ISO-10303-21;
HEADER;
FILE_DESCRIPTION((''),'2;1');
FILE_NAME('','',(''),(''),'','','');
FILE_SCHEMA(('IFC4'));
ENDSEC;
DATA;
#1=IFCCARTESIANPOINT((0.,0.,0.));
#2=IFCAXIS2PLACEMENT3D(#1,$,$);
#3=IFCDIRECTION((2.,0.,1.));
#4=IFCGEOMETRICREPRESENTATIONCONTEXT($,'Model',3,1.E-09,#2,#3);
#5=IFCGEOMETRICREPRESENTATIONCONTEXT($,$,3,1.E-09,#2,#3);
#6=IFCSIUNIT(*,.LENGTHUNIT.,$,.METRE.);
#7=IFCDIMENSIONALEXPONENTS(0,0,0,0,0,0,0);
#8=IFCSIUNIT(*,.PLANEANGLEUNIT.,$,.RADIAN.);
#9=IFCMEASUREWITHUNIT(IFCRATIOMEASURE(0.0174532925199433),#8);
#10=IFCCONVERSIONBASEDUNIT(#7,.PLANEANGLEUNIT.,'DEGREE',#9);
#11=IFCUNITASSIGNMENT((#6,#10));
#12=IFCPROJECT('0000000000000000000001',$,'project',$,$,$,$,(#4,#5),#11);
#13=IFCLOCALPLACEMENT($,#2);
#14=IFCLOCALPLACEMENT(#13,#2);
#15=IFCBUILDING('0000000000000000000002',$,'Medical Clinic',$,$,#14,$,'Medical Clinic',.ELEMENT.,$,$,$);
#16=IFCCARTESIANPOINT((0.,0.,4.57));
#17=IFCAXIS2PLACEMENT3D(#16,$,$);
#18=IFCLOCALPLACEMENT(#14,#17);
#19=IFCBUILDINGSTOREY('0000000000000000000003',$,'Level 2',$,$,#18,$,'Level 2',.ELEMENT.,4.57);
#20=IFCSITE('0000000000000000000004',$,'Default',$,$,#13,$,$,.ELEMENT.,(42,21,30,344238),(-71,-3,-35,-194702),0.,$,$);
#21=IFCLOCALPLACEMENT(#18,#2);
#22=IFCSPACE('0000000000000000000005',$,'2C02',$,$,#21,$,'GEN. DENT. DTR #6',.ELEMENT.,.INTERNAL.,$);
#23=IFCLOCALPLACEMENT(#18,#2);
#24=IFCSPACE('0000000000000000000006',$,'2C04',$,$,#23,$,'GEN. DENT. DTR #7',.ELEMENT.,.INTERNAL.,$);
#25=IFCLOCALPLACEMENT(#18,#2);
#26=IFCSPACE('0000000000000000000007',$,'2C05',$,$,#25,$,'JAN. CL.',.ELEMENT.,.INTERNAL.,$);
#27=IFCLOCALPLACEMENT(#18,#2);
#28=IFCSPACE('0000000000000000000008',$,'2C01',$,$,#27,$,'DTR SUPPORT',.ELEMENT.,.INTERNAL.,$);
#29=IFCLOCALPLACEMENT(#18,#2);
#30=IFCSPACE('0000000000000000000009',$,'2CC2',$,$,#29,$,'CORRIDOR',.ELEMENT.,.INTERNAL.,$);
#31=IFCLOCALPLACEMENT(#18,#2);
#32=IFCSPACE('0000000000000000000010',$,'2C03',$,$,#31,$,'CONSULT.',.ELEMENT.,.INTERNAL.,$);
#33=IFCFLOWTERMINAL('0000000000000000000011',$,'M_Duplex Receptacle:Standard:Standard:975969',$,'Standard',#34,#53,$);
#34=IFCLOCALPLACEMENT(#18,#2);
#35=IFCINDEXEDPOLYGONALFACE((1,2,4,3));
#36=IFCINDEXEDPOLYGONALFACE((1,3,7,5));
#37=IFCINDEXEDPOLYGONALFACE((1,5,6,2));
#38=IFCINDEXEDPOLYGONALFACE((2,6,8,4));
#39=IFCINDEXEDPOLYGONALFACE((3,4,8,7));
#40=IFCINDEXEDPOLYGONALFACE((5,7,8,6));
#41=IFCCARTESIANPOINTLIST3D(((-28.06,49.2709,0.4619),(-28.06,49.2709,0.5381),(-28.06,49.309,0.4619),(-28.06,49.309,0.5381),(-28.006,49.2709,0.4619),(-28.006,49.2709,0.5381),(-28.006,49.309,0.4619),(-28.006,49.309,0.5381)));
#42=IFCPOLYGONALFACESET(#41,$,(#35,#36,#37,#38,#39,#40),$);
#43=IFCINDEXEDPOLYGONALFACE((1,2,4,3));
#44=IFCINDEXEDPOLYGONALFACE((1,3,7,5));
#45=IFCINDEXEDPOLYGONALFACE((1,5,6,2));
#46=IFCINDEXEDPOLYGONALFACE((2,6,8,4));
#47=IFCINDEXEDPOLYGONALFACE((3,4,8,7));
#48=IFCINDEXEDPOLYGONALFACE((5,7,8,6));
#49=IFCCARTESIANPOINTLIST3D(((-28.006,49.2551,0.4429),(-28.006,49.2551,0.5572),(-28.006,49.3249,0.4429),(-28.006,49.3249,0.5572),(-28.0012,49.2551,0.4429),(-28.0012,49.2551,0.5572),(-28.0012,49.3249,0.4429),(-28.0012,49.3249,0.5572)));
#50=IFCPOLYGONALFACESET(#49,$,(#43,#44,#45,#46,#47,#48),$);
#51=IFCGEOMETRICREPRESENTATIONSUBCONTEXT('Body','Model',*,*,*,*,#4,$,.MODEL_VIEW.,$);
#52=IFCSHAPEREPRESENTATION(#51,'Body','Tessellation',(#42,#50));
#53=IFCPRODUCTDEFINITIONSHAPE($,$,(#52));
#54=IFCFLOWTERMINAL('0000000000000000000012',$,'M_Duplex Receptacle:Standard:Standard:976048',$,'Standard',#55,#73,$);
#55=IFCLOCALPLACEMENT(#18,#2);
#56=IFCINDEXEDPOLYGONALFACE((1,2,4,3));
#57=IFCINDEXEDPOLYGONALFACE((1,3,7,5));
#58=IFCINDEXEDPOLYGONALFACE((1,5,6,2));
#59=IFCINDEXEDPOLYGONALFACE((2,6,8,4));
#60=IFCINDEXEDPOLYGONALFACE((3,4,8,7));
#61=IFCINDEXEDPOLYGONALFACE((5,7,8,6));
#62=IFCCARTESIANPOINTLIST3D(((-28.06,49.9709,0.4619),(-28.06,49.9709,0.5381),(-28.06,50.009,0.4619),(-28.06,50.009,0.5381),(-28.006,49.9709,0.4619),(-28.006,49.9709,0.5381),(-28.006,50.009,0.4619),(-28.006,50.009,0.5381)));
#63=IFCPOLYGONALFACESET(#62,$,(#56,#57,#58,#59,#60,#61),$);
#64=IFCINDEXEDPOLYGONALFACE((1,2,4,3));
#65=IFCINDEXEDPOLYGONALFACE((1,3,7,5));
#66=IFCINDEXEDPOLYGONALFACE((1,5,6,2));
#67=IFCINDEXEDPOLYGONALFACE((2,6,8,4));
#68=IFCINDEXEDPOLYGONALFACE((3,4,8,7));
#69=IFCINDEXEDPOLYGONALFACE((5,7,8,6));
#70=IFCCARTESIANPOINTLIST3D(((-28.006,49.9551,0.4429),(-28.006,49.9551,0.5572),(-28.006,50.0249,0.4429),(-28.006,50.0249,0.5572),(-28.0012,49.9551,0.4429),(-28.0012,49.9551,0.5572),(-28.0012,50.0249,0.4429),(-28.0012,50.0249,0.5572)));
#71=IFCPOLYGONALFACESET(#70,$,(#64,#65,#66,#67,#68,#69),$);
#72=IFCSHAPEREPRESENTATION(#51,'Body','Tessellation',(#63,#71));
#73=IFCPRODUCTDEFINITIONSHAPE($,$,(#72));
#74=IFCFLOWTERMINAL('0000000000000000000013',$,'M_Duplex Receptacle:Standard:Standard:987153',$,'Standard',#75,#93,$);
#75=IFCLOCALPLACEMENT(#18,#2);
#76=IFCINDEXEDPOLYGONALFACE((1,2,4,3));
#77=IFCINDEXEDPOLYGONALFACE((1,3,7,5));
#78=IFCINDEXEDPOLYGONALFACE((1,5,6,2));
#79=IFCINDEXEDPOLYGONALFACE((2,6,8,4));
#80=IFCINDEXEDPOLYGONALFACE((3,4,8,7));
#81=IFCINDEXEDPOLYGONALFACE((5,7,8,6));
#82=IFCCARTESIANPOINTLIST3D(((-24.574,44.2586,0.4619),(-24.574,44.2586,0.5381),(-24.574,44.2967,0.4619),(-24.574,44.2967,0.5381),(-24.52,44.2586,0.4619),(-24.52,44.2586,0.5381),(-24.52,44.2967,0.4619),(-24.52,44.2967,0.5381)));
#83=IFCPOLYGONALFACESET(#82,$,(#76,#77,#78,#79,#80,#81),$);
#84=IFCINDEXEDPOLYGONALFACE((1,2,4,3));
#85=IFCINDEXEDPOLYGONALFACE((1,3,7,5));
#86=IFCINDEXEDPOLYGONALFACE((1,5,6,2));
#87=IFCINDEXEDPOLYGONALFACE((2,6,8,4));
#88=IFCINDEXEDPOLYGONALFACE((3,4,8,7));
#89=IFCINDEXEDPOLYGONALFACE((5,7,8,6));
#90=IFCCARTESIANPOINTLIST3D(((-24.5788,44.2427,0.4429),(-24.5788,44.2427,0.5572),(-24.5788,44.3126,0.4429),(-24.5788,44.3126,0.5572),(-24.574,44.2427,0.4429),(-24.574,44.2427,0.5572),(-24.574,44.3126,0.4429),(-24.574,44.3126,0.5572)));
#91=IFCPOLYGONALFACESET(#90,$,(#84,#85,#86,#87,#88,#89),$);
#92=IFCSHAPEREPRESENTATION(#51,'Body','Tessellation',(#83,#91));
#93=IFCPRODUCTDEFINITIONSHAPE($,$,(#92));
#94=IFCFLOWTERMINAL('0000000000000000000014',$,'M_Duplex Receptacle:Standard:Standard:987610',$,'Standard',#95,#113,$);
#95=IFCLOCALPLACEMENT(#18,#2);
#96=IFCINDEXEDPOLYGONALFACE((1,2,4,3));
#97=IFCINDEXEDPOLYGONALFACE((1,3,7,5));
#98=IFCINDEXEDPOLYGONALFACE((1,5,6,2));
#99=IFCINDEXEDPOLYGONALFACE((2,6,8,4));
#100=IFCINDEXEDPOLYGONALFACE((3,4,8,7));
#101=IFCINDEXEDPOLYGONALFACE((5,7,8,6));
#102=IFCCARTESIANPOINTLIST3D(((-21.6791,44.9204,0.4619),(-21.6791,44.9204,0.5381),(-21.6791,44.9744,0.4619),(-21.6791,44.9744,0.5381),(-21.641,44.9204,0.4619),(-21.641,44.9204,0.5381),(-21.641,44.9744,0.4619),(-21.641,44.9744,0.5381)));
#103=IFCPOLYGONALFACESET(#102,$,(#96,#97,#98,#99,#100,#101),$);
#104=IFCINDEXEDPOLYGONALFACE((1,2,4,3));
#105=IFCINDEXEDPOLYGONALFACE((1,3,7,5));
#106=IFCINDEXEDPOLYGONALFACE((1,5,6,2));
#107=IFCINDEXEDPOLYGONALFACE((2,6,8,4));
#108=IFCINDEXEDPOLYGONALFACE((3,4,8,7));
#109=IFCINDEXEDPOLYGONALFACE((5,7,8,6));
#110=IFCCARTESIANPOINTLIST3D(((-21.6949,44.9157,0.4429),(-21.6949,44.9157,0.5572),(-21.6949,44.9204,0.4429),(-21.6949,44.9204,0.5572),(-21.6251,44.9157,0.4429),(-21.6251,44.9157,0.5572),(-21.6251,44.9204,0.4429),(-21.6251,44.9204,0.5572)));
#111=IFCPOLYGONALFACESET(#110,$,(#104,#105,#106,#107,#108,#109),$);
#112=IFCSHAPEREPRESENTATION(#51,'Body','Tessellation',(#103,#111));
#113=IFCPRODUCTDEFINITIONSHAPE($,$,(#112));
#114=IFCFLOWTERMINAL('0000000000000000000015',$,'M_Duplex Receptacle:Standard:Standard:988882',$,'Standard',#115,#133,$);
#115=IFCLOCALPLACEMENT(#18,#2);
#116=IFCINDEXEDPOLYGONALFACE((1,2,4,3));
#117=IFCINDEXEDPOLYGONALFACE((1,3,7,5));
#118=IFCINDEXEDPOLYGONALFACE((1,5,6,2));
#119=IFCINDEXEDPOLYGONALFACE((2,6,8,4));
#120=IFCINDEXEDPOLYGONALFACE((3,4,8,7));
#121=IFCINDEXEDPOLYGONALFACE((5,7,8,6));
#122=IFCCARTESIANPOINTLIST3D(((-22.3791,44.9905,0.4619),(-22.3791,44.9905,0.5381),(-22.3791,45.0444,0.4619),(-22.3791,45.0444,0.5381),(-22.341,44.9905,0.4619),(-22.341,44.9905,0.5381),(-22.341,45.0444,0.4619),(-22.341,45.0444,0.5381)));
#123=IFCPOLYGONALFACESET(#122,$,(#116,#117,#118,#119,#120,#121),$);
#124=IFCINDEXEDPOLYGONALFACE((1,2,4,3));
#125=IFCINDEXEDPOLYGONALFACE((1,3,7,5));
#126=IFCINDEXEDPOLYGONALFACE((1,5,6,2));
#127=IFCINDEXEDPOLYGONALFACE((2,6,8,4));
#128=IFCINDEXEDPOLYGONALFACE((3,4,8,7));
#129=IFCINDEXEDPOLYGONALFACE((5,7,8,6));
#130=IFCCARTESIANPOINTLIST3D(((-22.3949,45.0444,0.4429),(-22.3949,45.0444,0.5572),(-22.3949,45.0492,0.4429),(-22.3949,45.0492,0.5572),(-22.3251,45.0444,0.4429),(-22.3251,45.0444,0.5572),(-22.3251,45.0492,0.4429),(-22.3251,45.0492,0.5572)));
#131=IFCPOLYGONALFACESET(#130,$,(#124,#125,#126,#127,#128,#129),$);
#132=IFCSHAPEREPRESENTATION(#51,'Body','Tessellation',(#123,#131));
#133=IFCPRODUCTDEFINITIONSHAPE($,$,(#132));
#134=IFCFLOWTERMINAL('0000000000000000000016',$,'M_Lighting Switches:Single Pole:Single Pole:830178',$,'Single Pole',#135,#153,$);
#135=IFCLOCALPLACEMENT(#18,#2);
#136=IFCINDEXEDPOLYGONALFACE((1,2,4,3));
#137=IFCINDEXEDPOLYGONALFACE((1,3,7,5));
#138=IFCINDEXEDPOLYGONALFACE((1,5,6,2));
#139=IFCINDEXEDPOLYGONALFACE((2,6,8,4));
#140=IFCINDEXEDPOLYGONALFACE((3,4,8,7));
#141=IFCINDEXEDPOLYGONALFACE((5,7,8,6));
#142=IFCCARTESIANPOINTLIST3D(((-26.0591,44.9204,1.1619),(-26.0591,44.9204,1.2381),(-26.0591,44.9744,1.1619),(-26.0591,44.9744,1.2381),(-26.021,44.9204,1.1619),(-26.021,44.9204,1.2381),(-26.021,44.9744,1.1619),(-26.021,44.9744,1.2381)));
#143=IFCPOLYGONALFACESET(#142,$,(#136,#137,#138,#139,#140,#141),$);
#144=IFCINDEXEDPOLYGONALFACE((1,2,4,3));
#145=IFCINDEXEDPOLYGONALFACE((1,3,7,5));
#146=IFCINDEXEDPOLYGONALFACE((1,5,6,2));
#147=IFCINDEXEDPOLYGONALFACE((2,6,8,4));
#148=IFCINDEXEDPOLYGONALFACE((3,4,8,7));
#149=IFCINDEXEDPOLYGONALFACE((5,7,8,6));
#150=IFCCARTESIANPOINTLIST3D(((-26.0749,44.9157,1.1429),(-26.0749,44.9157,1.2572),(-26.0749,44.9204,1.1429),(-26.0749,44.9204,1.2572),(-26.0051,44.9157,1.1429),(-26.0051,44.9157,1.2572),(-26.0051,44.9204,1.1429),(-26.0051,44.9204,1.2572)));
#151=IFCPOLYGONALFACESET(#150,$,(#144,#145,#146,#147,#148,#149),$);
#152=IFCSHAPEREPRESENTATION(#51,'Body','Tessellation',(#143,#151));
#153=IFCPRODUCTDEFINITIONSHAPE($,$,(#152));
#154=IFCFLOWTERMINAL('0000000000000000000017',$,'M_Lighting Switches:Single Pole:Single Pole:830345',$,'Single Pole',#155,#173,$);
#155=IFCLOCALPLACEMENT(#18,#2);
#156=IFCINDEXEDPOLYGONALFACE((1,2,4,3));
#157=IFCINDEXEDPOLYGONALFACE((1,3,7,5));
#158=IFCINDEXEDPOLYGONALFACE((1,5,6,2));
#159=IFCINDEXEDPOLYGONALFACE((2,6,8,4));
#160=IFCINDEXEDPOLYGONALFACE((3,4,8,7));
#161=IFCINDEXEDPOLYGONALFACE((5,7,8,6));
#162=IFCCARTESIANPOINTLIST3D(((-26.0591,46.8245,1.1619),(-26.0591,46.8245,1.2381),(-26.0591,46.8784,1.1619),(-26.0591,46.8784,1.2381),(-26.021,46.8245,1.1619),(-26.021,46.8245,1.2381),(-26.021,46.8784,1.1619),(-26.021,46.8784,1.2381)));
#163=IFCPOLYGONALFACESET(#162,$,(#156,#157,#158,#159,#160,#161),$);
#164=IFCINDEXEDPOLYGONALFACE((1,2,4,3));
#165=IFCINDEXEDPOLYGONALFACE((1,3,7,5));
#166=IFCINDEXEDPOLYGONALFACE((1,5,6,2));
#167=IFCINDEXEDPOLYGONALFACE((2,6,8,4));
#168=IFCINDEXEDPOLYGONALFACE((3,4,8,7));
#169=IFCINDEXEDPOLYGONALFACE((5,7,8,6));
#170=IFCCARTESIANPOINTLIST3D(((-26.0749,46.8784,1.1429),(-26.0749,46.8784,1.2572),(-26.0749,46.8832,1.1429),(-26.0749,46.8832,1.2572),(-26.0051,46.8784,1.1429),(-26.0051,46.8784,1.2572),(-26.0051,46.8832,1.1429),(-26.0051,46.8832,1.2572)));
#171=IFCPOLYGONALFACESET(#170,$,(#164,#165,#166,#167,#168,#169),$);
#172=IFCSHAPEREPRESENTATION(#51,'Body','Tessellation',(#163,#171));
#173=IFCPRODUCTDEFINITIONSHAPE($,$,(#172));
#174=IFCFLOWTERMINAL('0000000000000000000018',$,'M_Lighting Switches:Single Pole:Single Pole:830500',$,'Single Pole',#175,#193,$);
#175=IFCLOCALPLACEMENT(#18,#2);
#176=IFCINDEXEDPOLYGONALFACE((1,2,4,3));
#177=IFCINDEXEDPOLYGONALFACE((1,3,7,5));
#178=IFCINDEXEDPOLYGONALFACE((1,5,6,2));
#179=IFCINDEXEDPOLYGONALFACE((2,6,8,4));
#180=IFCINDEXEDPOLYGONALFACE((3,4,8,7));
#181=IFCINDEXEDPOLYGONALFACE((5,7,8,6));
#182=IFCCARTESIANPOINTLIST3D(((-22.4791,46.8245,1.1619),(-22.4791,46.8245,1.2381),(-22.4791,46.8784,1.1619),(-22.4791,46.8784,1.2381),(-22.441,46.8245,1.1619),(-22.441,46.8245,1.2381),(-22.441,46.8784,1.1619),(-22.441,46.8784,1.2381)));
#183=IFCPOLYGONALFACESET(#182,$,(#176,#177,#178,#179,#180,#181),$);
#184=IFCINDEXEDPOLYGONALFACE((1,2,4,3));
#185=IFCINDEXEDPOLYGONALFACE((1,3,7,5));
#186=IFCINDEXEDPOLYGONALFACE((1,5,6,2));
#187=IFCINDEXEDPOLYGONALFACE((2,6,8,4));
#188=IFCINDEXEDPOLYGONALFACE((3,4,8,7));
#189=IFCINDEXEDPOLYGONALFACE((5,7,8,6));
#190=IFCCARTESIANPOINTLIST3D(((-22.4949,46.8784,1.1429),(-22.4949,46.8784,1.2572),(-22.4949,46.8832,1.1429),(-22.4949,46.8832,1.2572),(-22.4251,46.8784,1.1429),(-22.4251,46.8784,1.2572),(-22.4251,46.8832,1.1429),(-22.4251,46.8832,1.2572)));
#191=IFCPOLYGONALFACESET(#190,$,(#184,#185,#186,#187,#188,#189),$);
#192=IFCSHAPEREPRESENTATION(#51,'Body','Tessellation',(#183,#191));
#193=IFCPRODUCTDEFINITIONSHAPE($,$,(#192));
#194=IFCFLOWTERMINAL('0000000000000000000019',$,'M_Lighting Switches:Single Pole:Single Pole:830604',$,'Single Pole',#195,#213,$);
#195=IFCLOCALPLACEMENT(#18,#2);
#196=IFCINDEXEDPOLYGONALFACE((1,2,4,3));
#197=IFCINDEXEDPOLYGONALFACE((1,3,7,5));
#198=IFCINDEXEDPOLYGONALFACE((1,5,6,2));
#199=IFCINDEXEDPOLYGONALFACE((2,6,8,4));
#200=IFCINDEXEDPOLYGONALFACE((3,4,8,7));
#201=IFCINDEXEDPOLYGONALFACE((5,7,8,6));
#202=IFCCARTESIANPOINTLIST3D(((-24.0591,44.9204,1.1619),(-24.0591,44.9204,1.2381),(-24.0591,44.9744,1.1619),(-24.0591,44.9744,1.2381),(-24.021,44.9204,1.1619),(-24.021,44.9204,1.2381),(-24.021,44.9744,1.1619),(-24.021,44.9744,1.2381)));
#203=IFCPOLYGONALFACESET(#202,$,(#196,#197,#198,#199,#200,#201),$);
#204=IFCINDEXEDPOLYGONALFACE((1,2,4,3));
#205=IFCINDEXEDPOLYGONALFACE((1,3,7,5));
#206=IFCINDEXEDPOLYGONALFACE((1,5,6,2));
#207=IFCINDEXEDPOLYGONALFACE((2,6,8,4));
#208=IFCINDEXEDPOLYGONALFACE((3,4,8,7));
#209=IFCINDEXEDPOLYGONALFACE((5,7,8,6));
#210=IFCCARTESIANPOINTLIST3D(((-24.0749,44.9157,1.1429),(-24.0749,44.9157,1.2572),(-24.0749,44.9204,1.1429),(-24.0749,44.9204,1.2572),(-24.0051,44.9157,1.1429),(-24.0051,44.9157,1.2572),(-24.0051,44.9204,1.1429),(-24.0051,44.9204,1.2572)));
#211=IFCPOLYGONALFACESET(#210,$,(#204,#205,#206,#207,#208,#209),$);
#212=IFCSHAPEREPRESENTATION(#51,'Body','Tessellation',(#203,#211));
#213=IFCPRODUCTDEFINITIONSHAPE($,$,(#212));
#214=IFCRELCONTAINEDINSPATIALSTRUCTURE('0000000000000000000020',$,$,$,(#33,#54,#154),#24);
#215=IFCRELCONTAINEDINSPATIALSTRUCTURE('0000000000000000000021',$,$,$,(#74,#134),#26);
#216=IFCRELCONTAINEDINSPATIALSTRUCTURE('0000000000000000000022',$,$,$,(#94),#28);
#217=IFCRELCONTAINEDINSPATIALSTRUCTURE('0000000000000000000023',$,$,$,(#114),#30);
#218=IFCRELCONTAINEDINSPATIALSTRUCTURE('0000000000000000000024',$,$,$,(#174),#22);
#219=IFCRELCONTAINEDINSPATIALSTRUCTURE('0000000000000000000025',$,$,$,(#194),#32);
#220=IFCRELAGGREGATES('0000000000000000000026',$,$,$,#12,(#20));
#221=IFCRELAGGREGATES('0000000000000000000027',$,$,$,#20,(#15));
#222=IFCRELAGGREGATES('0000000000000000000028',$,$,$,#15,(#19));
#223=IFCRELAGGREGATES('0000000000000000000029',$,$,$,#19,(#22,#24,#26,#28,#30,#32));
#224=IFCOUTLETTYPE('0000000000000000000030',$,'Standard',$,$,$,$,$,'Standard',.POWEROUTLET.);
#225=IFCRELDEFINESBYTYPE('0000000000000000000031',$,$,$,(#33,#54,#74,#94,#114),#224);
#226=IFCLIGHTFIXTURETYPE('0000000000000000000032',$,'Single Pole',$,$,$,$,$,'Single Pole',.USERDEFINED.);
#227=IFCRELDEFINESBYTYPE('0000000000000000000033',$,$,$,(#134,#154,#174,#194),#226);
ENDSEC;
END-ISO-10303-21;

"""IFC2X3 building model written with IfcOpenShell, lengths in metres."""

from ifc_helpers import new_model, entity, si_unit, converted_unit, direction, frame, frame_2d, origin, origin_2d_with_axis, place, context, subcontext, project, spatial, rectangle, extrude, source, transform, mapped, type_object, type_shapes, element, save


model = new_model("IFC2X3")

# Units and contexts
model_context = context("Model", 3, precision=1e-09, world=origin(), true_north=direction((2.0, 0.0, 1.0)))
context_of_model = context(None, 3, precision=1e-09, world=origin(), true_north=direction((2.0, 0.0, 1.0)))
body_context = subcontext(model_context, "Body", "Model", "MODEL_VIEW")
ifc_project = project(units=[si_unit("LENGTHUNIT", "METRE"), converted_unit("PLANEANGLEUNIT", "DEGREE", entity("IfcRatioMeasure", 0.0174532925199433), si_unit("PLANEANGLEUNIT", "RADIAN"), dimensions=[0, 0, 0, 0, 0, 0, 0])], contexts=[model_context, context_of_model])

# Site, building, storey, space
site_placement = place(None, origin())
site = spatial("IfcSite", under=ifc_project, at=site_placement, Name="Default", CompositionType="ELEMENT", RefLatitude=(42, 21, 30, 344238), RefLongitude=(-71, -3, -35, -194702), RefElevation=0.0)
building_placement = place(site_placement, origin())
building = spatial("IfcBuilding", under=site, at=building_placement, Name="Medical Clinic", LongName="Medical Clinic", CompositionType="ELEMENT")
storey_placement = place(building_placement, frame((0.0, 0.0, 4.57)))
storey = spatial("IfcBuildingStorey", under=building, at=storey_placement, Name="Level 2", LongName="Level 2", CompositionType="ELEMENT", Elevation=4.57)
space_1_placement = place(storey_placement, origin())
space_1 = spatial("IfcSpace", under=storey, at=space_1_placement, Name="2C02", LongName="GEN. DENT. DTR #6", CompositionType="ELEMENT", InteriorOrExteriorSpace="INTERNAL")

# Shared definitions
outlet_type = type_object("IfcOutletType", Name="Standard", ElementType="Standard", PredefinedType="POWEROUTLET")
shared_shape_1 = source(origin(), body_context, "Body", "SweptSolid", [
    extrude(rectangle(XDim=0.0381, YDim=0.0762, at=origin_2d_with_axis()), frame((0.0, 0.0, -0.054), z_axis=(0.0, 0.0, 1.0), x_axis=(-1.0, 0.0, 0.0)), (0.0, 0.0, 1.0), 0.054),
    extrude(rectangle(XDim=0.0698, YDim=0.1143, at=frame_2d((0.0, 0.0), x_axis=(1.0, 0.0))), frame((0.0, 0.0, 0.0), z_axis=(0.0, 0.0, 1.0), x_axis=(-1.0, 0.0, 0.0)), (0.0, 0.0, 1.0), 0.0048),
])
type_shapes(outlet_type, [shared_shape_1])

# Shared definitions
space_2_placement = place(storey_placement, origin())
space_2 = spatial("IfcSpace", under=storey, at=space_2_placement, Name="2C04", LongName="GEN. DENT. DTR #7", CompositionType="ELEMENT", InteriorOrExteriorSpace="INTERNAL")

# Flow terminals
for number, where, z_axis, x_axis, name in (
    (1, (-28.006, 49.29, 0.5), (1.0, 0.0, 0.0), (0.0, 1.0, 0.0), "M_Duplex Receptacle:Standard:Standard:975969"),
    (2, (-28.006, 49.99, 0.5), (1.0, 0.0, 0.0), (0.0, 1.0, 0.0), "M_Duplex Receptacle:Standard:Standard:976048"),
):
    element("IfcFlowTerminal", number, at=place(space_2_placement, frame(where, z_axis=z_axis, x_axis=x_axis)), inside=space_2, type_object=outlet_type, Name=name, ObjectType="Standard", context=body_context, shape_type="MappedRepresentation", body=[
        mapped(shared_shape_1, transform((0.0, 0.0, 0.0), scale=1.0)),
    ])

# Shared definitions
space_3_placement = place(storey_placement, origin())
space_3 = spatial("IfcSpace", under=storey, at=space_3_placement, Name="2C05", LongName="JAN. CL.", CompositionType="ELEMENT", InteriorOrExteriorSpace="INTERNAL")

# Flow terminal
flow_terminal_1_placement = place(space_3_placement, frame((-24.574, 44.2776, 0.5), z_axis=(-1.0, 0.0, 0.0), x_axis=(0.0, -1.0, 0.0)))
element("IfcFlowTerminal", 3, at=flow_terminal_1_placement, inside=space_3, type_object=outlet_type, Name="M_Duplex Receptacle:Standard:Standard:987153", ObjectType="Standard", context=body_context, shape_type="MappedRepresentation", body=[
    mapped(shared_shape_1, transform((0.0, 0.0, 0.0), scale=1.0)),
])

# Shared definitions
space_4_placement = place(storey_placement, origin())
space_4 = spatial("IfcSpace", under=storey, at=space_4_placement, Name="2C01", LongName="DTR SUPPORT", CompositionType="ELEMENT", InteriorOrExteriorSpace="INTERNAL")

# Flow terminal
flow_terminal_2_placement = place(space_4_placement, frame((-21.66, 44.9204, 0.5), z_axis=(0.0, -1.0, 0.0), x_axis=(1.0, 0.0, 0.0)))
element("IfcFlowTerminal", 4, at=flow_terminal_2_placement, inside=space_4, type_object=outlet_type, Name="M_Duplex Receptacle:Standard:Standard:987610", ObjectType="Standard", context=body_context, shape_type="MappedRepresentation", body=[
    mapped(shared_shape_1, transform((0.0, 0.0, 0.0), scale=1.0)),
])

# Shared definitions
space_5_placement = place(storey_placement, origin())
space_5 = spatial("IfcSpace", under=storey, at=space_5_placement, Name="2CC2", LongName="CORRIDOR", CompositionType="ELEMENT", InteriorOrExteriorSpace="INTERNAL")

# Flow terminals
flow_terminal_3_placement = place(space_5_placement, frame((-22.36, 45.0444, 0.5), z_axis=(0.0, 1.0, 0.0), x_axis=(-1.0, 0.0, 0.0)))
element("IfcFlowTerminal", 5, at=flow_terminal_3_placement, inside=space_5, type_object=outlet_type, Name="M_Duplex Receptacle:Standard:Standard:988882", ObjectType="Standard", context=body_context, shape_type="MappedRepresentation", body=[
    mapped(shared_shape_1, transform((0.0, 0.0, 0.0), scale=1.0)),
])
light_fixture_type_1 = type_object("IfcLightFixtureType", Name="Single Pole", ElementType="Single Pole", PredefinedType="USERDEFINED")
shared_shape_2 = source(origin(), body_context, "Body", "SweptSolid", [
    extrude(rectangle(XDim=0.0381, YDim=0.0762, at=origin_2d_with_axis()), frame((0.0, 0.0, -0.054), z_axis=(0.0, 0.0, 1.0), x_axis=(-1.0, 0.0, 0.0)), (0.0, 0.0, 1.0), 0.054),
    extrude(rectangle(XDim=0.0698, YDim=0.1143, at=frame_2d((0.0, 0.0), x_axis=(1.0, 0.0))), frame((0.0, 0.0, 0.0), z_axis=(0.0, 0.0, 1.0), x_axis=(-1.0, 0.0, 0.0)), (0.0, 0.0, 1.0), 0.0048),
])
type_shapes(light_fixture_type_1, [shared_shape_2])
flow_terminal_4_placement = place(space_3_placement, frame((-26.04, 44.9204, 1.2), z_axis=(0.0, -1.0, 0.0), x_axis=(1.0, 0.0, 0.0)))
element("IfcFlowTerminal", 6, at=flow_terminal_4_placement, inside=space_3, type_object=light_fixture_type_1, Name="M_Lighting Switches:Single Pole:Single Pole:830178", ObjectType="Single Pole", context=body_context, shape_type="MappedRepresentation", body=[
    mapped(shared_shape_2, transform((0.0, 0.0, 0.0), scale=1.0)),
])
flow_terminal_5_placement = place(space_2_placement, frame((-26.04, 46.8784, 1.2), z_axis=(0.0, 1.0, 0.0), x_axis=(-1.0, 0.0, 0.0)))
element("IfcFlowTerminal", 7, at=flow_terminal_5_placement, inside=space_2, type_object=light_fixture_type_1, Name="M_Lighting Switches:Single Pole:Single Pole:830345", ObjectType="Single Pole", context=body_context, shape_type="MappedRepresentation", body=[
    mapped(shared_shape_2, transform((0.0, 0.0, 0.0), scale=1.0)),
])
flow_terminal_6_placement = place(space_1_placement, frame((-22.46, 46.8784, 1.2), z_axis=(0.0, 1.0, 0.0), x_axis=(-1.0, 0.0, 0.0)))
element("IfcFlowTerminal", 8, at=flow_terminal_6_placement, inside=space_1, type_object=light_fixture_type_1, Name="M_Lighting Switches:Single Pole:Single Pole:830500", ObjectType="Single Pole", context=body_context, shape_type="MappedRepresentation", body=[
    mapped(shared_shape_2, transform((0.0, 0.0, 0.0), scale=1.0)),
])

# Shared definitions
space_6_placement = place(storey_placement, origin())
space_6 = spatial("IfcSpace", under=storey, at=space_6_placement, Name="2C03", LongName="CONSULT.", CompositionType="ELEMENT", InteriorOrExteriorSpace="INTERNAL")

# Flow terminal
flow_terminal_7_placement = place(space_6_placement, frame((-24.04, 44.9204, 1.2), z_axis=(0.0, -1.0, 0.0), x_axis=(1.0, 0.0, 0.0)))
element("IfcFlowTerminal", 9, at=flow_terminal_7_placement, inside=space_6, type_object=light_fixture_type_1, Name="M_Lighting Switches:Single Pole:Single Pole:830604", ObjectType="Single Pole", context=body_context, shape_type="MappedRepresentation", body=[
    mapped(shared_shape_2, transform((0.0, 0.0, 0.0), scale=1.0)),
])

save(model, "model.ifc")
